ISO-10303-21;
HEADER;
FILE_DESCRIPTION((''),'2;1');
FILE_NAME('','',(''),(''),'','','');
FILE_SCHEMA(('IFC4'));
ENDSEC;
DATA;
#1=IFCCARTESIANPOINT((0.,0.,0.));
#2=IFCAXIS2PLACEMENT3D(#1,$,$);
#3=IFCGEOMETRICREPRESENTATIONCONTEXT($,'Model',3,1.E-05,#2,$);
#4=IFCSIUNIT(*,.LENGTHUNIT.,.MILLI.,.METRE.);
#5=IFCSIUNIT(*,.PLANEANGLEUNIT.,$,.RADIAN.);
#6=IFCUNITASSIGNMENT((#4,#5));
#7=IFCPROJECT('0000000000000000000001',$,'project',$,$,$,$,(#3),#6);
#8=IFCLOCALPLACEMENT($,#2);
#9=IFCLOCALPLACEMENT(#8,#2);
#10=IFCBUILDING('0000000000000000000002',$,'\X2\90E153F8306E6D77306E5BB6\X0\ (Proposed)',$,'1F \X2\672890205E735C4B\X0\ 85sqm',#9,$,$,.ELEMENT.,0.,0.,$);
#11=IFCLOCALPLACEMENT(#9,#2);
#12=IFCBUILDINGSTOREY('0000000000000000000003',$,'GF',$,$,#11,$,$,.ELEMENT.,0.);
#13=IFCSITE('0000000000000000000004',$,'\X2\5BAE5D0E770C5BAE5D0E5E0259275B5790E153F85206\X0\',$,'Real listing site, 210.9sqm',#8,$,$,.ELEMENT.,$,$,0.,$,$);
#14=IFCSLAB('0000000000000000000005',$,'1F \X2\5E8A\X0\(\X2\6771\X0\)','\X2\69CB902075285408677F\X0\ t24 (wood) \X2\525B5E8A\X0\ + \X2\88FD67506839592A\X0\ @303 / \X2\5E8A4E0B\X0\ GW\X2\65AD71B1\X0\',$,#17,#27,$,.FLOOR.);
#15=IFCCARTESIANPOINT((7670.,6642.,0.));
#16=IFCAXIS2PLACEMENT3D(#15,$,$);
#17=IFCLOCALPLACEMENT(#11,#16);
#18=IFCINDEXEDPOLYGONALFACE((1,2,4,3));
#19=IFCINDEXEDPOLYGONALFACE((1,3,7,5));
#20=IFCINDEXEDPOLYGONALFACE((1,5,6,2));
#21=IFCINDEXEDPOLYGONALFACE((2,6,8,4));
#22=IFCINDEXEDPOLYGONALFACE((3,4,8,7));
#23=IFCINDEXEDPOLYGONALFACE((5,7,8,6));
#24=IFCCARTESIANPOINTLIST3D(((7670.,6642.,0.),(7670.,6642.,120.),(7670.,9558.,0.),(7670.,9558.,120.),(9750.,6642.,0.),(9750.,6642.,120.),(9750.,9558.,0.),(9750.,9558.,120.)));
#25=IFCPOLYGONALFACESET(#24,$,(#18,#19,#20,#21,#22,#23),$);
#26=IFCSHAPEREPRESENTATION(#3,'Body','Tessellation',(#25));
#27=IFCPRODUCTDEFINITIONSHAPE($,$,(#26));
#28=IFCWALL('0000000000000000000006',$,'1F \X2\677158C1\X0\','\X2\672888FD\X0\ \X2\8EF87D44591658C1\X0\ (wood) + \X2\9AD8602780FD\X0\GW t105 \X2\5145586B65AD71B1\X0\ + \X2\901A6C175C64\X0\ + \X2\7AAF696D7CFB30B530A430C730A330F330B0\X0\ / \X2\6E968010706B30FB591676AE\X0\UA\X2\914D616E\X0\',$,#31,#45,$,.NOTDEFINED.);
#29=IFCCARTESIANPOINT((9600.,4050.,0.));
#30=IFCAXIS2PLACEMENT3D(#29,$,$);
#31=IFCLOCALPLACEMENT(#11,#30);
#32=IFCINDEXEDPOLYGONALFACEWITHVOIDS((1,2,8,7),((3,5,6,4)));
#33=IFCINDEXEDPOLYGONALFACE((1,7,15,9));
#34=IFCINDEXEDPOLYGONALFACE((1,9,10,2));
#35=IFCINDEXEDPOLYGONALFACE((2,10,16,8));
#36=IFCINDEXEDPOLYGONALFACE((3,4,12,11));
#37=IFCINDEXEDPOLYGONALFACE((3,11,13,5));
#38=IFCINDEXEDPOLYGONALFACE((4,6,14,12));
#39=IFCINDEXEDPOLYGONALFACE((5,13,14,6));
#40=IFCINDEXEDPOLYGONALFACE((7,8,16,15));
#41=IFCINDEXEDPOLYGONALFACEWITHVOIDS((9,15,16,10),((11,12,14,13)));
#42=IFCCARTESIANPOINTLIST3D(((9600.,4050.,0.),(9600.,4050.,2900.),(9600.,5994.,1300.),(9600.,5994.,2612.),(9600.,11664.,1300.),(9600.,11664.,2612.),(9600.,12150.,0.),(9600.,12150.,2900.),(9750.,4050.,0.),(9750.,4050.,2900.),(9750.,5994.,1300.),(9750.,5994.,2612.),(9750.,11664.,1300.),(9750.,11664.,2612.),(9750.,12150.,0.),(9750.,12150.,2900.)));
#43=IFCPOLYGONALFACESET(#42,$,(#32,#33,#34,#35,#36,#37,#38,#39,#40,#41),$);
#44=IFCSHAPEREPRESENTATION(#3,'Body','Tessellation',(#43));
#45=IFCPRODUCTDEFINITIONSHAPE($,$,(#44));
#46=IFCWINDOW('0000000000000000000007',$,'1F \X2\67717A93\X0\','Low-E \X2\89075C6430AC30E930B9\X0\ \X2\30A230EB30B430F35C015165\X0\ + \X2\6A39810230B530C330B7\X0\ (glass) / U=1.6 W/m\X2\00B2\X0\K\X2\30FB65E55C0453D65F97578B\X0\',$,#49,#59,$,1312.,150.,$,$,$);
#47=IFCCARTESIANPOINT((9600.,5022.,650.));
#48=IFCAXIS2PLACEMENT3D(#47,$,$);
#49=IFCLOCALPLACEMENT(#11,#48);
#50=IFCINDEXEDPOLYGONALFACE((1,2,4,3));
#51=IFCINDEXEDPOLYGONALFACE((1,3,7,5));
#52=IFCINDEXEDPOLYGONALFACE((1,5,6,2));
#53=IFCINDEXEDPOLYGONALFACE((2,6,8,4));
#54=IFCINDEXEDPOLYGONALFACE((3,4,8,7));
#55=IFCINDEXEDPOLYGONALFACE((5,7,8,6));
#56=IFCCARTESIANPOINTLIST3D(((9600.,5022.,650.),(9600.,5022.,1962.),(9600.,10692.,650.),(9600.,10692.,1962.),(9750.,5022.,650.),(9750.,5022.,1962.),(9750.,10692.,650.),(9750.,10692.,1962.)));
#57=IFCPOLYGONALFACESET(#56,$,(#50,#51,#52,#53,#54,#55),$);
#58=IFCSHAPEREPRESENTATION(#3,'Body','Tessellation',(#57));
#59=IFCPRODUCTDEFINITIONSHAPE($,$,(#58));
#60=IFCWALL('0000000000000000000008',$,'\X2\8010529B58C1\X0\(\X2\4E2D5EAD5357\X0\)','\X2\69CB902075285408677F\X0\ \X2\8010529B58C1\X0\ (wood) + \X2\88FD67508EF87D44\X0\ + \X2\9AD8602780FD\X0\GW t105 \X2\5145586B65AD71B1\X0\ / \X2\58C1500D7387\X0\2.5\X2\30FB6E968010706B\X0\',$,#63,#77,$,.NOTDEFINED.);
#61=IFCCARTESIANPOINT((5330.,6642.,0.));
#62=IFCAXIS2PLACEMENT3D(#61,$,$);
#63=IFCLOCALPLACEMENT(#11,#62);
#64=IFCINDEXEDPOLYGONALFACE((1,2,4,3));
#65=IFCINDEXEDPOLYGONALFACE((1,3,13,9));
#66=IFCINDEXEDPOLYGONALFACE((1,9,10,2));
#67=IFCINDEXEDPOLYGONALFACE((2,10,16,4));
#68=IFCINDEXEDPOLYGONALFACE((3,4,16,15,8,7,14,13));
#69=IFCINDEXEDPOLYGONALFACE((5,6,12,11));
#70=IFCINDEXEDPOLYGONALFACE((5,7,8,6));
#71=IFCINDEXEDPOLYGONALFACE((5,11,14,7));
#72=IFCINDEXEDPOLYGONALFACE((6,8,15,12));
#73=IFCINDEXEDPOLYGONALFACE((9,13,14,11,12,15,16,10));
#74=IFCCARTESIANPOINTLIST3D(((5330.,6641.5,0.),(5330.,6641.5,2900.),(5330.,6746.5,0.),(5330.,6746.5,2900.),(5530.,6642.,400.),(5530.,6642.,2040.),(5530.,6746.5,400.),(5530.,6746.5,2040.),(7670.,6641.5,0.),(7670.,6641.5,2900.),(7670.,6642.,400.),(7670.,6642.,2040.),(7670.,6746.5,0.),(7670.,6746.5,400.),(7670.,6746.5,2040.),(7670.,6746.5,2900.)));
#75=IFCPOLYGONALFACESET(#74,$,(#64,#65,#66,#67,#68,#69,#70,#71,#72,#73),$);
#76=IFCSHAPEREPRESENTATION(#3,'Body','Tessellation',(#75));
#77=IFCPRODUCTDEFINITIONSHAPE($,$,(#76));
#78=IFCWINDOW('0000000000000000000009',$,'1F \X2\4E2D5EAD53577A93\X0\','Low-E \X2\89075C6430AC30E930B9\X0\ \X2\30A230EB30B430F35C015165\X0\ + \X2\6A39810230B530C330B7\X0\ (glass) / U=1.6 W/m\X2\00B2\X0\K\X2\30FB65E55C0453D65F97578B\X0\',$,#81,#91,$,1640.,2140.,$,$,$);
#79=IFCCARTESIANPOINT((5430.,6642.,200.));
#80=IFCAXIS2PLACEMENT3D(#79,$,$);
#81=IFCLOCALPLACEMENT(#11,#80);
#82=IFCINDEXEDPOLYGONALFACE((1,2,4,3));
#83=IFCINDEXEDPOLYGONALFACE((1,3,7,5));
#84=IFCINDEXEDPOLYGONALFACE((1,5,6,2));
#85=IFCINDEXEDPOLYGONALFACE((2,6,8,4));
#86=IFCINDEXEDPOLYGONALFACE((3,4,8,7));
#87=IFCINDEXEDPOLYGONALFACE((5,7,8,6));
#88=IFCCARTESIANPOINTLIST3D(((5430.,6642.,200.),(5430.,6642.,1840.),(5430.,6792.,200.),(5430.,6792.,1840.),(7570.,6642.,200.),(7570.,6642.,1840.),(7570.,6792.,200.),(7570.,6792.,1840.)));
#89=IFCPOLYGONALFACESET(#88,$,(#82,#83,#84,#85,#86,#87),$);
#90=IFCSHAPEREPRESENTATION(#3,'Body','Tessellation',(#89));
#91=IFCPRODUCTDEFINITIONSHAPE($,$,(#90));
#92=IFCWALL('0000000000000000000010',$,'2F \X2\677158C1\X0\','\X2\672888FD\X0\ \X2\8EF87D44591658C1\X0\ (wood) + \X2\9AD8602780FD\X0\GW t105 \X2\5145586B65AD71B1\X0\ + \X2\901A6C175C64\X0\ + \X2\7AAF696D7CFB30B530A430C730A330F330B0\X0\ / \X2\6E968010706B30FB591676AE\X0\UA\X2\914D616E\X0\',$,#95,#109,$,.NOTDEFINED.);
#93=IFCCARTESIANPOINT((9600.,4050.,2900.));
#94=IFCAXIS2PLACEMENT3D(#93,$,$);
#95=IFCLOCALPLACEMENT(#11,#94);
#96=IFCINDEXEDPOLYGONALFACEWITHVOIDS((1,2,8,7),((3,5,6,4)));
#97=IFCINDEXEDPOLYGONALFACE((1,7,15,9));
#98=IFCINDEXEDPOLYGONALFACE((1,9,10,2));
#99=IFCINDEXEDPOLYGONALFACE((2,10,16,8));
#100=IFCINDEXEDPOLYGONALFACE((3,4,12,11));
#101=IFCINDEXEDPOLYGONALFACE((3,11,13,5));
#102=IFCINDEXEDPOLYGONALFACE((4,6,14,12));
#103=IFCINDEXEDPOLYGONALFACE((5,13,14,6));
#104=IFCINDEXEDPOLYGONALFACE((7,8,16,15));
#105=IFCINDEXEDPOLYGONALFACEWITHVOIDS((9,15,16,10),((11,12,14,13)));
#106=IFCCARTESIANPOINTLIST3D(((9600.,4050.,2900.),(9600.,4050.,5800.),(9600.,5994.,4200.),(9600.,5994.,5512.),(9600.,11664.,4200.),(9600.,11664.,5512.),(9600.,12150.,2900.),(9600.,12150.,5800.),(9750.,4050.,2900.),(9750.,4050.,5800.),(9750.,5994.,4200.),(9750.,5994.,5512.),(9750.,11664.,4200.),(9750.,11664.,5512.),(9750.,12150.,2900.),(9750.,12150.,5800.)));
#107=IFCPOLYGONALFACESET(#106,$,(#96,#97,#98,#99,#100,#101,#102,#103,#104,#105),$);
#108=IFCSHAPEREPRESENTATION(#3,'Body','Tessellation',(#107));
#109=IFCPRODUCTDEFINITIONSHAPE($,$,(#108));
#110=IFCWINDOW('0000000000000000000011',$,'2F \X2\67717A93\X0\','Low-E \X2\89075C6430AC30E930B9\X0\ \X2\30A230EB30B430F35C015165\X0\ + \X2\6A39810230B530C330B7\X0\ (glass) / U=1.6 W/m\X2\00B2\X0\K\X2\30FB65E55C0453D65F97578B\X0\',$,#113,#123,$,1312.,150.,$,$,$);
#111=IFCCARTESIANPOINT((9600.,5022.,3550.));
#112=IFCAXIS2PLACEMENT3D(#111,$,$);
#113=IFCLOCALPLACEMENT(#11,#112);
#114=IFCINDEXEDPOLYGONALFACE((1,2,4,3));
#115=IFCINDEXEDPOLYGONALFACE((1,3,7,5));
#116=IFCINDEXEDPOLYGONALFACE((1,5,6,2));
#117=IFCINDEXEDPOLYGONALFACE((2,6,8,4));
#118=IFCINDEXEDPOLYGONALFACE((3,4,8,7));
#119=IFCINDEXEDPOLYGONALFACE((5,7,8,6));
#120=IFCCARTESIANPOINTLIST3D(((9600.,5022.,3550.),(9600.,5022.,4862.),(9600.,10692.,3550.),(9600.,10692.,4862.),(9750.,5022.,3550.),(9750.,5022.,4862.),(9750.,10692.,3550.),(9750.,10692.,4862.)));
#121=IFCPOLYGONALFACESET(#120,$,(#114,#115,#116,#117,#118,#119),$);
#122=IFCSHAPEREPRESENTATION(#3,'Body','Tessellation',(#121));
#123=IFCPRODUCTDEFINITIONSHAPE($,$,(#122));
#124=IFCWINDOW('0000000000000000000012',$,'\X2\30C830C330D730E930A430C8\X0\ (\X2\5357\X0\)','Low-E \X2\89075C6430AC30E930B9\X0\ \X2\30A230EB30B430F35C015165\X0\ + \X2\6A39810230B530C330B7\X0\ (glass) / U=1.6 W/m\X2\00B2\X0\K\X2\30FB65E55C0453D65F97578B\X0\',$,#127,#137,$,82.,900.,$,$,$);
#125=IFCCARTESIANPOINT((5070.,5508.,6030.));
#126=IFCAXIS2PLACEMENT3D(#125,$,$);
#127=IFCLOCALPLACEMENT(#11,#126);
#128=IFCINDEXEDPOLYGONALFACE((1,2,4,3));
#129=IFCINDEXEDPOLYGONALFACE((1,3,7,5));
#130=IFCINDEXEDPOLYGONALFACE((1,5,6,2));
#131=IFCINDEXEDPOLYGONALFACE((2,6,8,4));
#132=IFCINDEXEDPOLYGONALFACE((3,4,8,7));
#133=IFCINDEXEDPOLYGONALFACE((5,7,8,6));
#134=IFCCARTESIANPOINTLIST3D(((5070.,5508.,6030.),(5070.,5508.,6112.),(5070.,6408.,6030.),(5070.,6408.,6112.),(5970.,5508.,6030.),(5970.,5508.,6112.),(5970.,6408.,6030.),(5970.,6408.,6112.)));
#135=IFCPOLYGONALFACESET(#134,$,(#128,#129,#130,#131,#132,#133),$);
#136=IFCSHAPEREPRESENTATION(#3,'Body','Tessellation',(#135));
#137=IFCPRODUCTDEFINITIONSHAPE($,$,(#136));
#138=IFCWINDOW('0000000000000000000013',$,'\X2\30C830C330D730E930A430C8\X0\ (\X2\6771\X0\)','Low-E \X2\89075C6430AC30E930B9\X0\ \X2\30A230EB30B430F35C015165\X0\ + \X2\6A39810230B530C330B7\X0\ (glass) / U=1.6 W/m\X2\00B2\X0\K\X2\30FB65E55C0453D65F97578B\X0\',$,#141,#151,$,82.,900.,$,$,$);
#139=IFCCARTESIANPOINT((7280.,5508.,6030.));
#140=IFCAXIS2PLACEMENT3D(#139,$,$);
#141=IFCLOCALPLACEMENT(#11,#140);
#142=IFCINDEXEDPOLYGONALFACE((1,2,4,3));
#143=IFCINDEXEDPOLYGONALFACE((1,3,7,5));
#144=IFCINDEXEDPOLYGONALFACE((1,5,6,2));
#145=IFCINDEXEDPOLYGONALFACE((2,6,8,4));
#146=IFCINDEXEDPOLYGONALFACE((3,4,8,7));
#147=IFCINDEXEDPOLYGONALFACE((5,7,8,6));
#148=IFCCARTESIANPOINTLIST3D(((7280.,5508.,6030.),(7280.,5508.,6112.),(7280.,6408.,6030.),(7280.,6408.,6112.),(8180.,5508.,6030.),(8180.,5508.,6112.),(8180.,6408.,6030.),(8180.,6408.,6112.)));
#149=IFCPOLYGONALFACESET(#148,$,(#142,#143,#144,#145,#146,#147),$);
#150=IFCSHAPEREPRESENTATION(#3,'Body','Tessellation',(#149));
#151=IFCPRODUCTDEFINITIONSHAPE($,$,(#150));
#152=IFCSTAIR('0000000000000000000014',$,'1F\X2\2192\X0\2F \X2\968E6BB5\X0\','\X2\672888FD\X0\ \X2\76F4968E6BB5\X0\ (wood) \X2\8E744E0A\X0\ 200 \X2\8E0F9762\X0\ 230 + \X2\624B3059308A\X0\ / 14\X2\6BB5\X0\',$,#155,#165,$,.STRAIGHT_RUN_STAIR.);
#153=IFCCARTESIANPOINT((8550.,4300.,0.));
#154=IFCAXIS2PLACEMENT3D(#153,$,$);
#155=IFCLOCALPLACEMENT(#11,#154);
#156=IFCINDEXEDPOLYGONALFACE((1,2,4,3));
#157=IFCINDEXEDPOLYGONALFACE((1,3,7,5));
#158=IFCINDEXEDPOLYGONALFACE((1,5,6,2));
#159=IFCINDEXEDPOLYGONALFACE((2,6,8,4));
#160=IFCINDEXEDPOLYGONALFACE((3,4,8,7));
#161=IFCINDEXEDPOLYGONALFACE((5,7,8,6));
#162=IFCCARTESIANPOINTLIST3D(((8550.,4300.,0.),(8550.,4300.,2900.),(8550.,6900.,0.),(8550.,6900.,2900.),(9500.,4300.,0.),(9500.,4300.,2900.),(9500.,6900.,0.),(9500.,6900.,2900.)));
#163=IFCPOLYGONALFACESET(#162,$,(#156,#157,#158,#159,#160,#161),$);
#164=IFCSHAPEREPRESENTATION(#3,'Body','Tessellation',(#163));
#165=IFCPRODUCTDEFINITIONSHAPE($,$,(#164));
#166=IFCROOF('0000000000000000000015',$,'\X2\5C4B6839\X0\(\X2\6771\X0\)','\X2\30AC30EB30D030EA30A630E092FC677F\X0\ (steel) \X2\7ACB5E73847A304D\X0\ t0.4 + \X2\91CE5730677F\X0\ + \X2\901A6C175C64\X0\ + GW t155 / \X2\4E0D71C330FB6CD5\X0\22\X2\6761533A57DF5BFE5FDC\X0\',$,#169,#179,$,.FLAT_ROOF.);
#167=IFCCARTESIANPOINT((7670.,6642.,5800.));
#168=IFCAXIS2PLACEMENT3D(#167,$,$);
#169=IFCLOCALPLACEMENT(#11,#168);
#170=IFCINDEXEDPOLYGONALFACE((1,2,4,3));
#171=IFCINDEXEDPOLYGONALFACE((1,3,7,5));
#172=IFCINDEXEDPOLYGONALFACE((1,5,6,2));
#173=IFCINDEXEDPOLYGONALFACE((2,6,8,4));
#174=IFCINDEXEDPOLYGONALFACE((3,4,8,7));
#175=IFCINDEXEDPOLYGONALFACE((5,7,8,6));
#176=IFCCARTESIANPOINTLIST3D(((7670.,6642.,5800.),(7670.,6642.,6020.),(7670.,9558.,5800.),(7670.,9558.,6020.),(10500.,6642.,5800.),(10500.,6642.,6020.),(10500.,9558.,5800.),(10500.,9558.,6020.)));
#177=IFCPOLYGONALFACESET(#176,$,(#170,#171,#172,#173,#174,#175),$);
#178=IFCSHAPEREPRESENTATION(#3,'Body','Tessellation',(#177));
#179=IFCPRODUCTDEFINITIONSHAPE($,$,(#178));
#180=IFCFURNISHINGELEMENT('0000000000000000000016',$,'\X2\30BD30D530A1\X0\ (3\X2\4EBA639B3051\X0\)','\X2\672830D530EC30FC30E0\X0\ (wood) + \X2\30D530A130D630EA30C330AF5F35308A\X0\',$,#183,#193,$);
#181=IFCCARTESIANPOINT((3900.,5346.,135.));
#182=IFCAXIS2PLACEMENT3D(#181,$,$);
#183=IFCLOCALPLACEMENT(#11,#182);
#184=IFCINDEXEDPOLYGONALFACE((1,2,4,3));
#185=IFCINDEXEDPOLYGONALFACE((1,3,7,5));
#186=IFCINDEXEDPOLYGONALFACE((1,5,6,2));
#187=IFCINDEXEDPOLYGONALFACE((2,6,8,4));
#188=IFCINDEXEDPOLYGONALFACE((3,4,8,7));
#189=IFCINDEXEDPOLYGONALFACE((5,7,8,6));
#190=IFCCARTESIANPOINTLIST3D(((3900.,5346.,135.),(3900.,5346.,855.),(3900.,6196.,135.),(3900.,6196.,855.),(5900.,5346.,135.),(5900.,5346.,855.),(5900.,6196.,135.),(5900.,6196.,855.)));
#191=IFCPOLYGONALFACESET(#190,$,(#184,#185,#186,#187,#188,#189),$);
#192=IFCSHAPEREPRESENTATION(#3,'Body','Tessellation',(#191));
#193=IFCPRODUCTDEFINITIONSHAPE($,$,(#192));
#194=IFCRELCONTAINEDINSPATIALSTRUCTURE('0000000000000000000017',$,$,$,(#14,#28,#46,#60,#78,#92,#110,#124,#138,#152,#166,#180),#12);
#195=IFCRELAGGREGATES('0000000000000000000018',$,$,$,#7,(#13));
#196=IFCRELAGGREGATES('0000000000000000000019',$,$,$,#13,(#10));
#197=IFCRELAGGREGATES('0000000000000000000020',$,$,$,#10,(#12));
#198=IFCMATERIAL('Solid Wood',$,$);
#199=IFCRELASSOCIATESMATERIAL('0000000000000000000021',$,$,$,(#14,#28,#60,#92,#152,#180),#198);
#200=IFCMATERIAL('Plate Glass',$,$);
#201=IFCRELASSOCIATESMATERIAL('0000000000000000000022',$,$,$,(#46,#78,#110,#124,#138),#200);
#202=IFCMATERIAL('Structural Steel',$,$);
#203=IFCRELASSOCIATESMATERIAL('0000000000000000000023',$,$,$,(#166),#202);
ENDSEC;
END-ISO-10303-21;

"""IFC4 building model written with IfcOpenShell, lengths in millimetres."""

from ifc_helpers import new_model, si_unit, frame, frame_2d, origin, place, context, project, spatial, rectangle, extrude, material, element, fill, save


model = new_model("IFC4")

# Units and contexts
model_context = context("Model", 3, precision=1e-05, world=origin())
ifc_project = project(units=[si_unit("LENGTHUNIT", "METRE", prefix="MILLI"), si_unit("PLANEANGLEUNIT", "RADIAN")], contexts=[model_context])

# Site, building, storey
site_placement = place(None, origin())
site = spatial("IfcSite", under=ifc_project, at=site_placement, Name="宮崎県宮崎市大字郡司分", ObjectType="Real listing site, 210.9sqm", CompositionType="ELEMENT", RefElevation=0.0)
building_placement = place(site_placement, origin())
building = spatial("IfcBuilding", under=site, at=building_placement, Name="郡司の海の家 (Proposed)", ObjectType="1F 木造平屋 85sqm", CompositionType="ELEMENT", ElevationOfRefHeight=0.0, ElevationOfTerrain=0.0)
storey_placement = place(building_placement, origin())
storey = spatial("IfcBuildingStorey", under=building, at=storey_placement, Name="GF", CompositionType="ELEMENT", Elevation=0.0)

# Slab
ifc_material_1 = material(Name="Solid Wood")
slab_placement = place(storey_placement, frame((7670.0, 6642.0, 0.0)))
element("IfcSlab", 1, at=slab_placement, inside=storey, material=ifc_material_1, Name="1F 床(東)", Description="構造用合板 t24 (wood) 剛床 + 製材根太 @303 / 床下 GW断熱", PredefinedType="FLOOR", context=model_context, shape_type="SweptSolid", body=[
    extrude(rectangle(XDim=2080.0, YDim=2916.0, at=frame_2d((1040.0, 1458.0))), frame((7670.0, 6642.0, 0.0)), (0.0, 0.0, 1.0), 120.0),
])

# Walls, openings, windows
wall_1_placement = place(storey_placement, frame((9600.0, 4050.0, 0.0)))
wall_1 = element("IfcWall", 2, at=wall_1_placement, inside=storey, material=ifc_material_1, Name="1F 東壁", Description="木製 軸組外壁 (wood) + 高性能GW t105 充填断熱 + 通気層 + 窯業系サイディング / 準耐火・外皮UA配慮", PredefinedType="NOTDEFINED", context=model_context, shape_type="SweptSolid", body=[
    extrude(rectangle(XDim=150.0, YDim=8100.0, at=frame_2d((75.0, 4050.0))), frame((9600.0, 4050.0, 0.0)), (0.0, 0.0, 1.0), 2900.0),
])
opening_1_placement = place(storey_placement, frame((9600.0, 5022.0, 650.0)))
opening_1 = element("IfcOpeningElement", 3, at=opening_1_placement, cuts=wall_1, PredefinedType="NOTDEFINED", context=model_context, shape_type="SweptSolid", body=[
    extrude(rectangle(XDim=150.0, YDim=5670.0, at=frame_2d((75.0, 2835.0))), frame((9600.0, 5022.0, 650.0)), (0.0, 0.0, 1.0), 1312.0),
])
ifc_material_2 = material(Name="Plate Glass")
window_1_placement = place(storey_placement, frame((9600.0, 5022.0, 650.0)))
window_1 = element("IfcWindow", 4, at=window_1_placement, inside=storey, material=ifc_material_2, Name="1F 東窓", Description="Low-E 複層ガラス アルゴン封入 + 樹脂サッシ (glass) / U=1.6 W/m²K・日射取得型", OverallHeight=1312.0, OverallWidth=150.0, context=model_context, shape_type="SweptSolid", body=[
    extrude(rectangle(XDim=150.0, YDim=5670.0, at=frame_2d((75.0, 2835.0))), frame((9600.0, 5022.0, 650.0)), (0.0, 0.0, 1.0), 1312.0),
])
fill(opening_1, window_1)
wall_2_placement = place(storey_placement, frame((5330.0, 6642.0, 0.0)))
wall_2 = element("IfcWall", 5, at=wall_2_placement, inside=storey, material=ifc_material_1, Name="耐力壁(中庭南)", Description="構造用合板 耐力壁 (wood) + 製材軸組 + 高性能GW t105 充填断熱 / 壁倍率2.5・準耐火", PredefinedType="NOTDEFINED", context=model_context, shape_type="SweptSolid", body=[
    extrude(rectangle(XDim=2340.0, YDim=105.0, at=frame_2d((1170.0, 52.0))), frame((5330.0, 6642.0, 0.0)), (0.0, 0.0, 1.0), 2900.0),
])
opening_2_placement = place(storey_placement, frame((5430.0, 6642.0, 200.0)))
opening_2 = element("IfcOpeningElement", 6, at=opening_2_placement, cuts=wall_2, PredefinedType="NOTDEFINED", context=model_context, shape_type="SweptSolid", body=[
    extrude(rectangle(XDim=2140.0, YDim=150.0, at=frame_2d((1070.0, 75.0))), frame((5430.0, 6642.0, 200.0)), (0.0, 0.0, 1.0), 1640.0),
])
window_2_placement = place(storey_placement, frame((5430.0, 6642.0, 200.0)))
window_2 = element("IfcWindow", 7, at=window_2_placement, inside=storey, material=ifc_material_2, Name="1F 中庭南窓", Description="Low-E 複層ガラス アルゴン封入 + 樹脂サッシ (glass) / U=1.6 W/m²K・日射取得型", OverallHeight=1640.0, OverallWidth=2140.0, context=model_context, shape_type="SweptSolid", body=[
    extrude(rectangle(XDim=2140.0, YDim=150.0, at=frame_2d((1070.0, 75.0))), frame((5430.0, 6642.0, 200.0)), (0.0, 0.0, 1.0), 1640.0),
])
fill(opening_2, window_2)

# Wall, opening, window
wall_3_placement = place(storey_placement, frame((9600.0, 4050.0, 2900.0)))
wall_3 = element("IfcWall", 8, at=wall_3_placement, inside=storey, material=ifc_material_1, Name="2F 東壁", Description="木製 軸組外壁 (wood) + 高性能GW t105 充填断熱 + 通気層 + 窯業系サイディング / 準耐火・外皮UA配慮", PredefinedType="NOTDEFINED", context=model_context, shape_type="SweptSolid", body=[
    extrude(rectangle(XDim=150.0, YDim=8100.0, at=frame_2d((75.0, 4050.0))), frame((9600.0, 4050.0, 2900.0)), (0.0, 0.0, 1.0), 2900.0),
])
opening_3_placement = place(storey_placement, frame((9600.0, 5022.0, 3550.0)))
opening_3 = element("IfcOpeningElement", 9, at=opening_3_placement, cuts=wall_3, PredefinedType="NOTDEFINED", context=model_context, shape_type="SweptSolid", body=[
    extrude(rectangle(XDim=150.0, YDim=5670.0, at=frame_2d((75.0, 2835.0))), frame((9600.0, 5022.0, 3550.0)), (0.0, 0.0, 1.0), 1312.0),
])
window_3_placement = place(storey_placement, frame((9600.0, 5022.0, 3550.0)))
window_3 = element("IfcWindow", 10, at=window_3_placement, inside=storey, material=ifc_material_2, Name="2F 東窓", Description="Low-E 複層ガラス アルゴン封入 + 樹脂サッシ (glass) / U=1.6 W/m²K・日射取得型", OverallHeight=1312.0, OverallWidth=150.0, context=model_context, shape_type="SweptSolid", body=[
    extrude(rectangle(XDim=150.0, YDim=5670.0, at=frame_2d((75.0, 2835.0))), frame((9600.0, 5022.0, 3550.0)), (0.0, 0.0, 1.0), 1312.0),
])
fill(opening_3, window_3)

# Windows
window_4_placement = place(storey_placement, frame((5070.0, 5508.0, 6030.0)))
element("IfcWindow", 11, at=window_4_placement, inside=storey, material=ifc_material_2, Name="トップライト (南)", Description="Low-E 複層ガラス アルゴン封入 + 樹脂サッシ (glass) / U=1.6 W/m²K・日射取得型", OverallHeight=82.0, OverallWidth=900.0, context=model_context, shape_type="SweptSolid", body=[
    extrude(rectangle(XDim=900.0, YDim=900.0, at=frame_2d((450.0, 450.0))), frame((5070.0, 5508.0, 6030.0)), (0.0, 0.0, 1.0), 82.0),
])
window_5_placement = place(storey_placement, frame((7280.0, 5508.0, 6030.0)))
element("IfcWindow", 12, at=window_5_placement, inside=storey, material=ifc_material_2, Name="トップライト (東)", Description="Low-E 複層ガラス アルゴン封入 + 樹脂サッシ (glass) / U=1.6 W/m²K・日射取得型", OverallHeight=82.0, OverallWidth=900.0, context=model_context, shape_type="SweptSolid", body=[
    extrude(rectangle(XDim=900.0, YDim=900.0, at=frame_2d((450.0, 450.0))), frame((7280.0, 5508.0, 6030.0)), (0.0, 0.0, 1.0), 82.0),
])

# Stair
stair_placement = place(storey_placement, frame((8550.0, 4300.0, 0.0)))
element("IfcStair", 13, at=stair_placement, inside=storey, material=ifc_material_1, Name="1F→2F 階段", Description="木製 直階段 (wood) 蹴上 200 踏面 230 + 手すり / 14段", PredefinedType="STRAIGHT_RUN_STAIR", context=model_context, shape_type="SweptSolid", body=[
    extrude(rectangle(XDim=950.0, YDim=2600.0, at=frame_2d((475.0, 1300.0))), frame((8550.0, 4300.0, 0.0)), (0.0, 0.0, 1.0), 2900.0),
])

# Roof
ifc_material_3 = material(Name="Structural Steel")
roof_placement = place(storey_placement, frame((7670.0, 6642.0, 5800.0)))
element("IfcRoof", 14, at=roof_placement, inside=storey, material=ifc_material_3, Name="屋根(東)", Description="ガルバリウム鋼板 (steel) 立平葺き t0.4 + 野地板 + 通気層 + GW t155 / 不燃・法22条区域対応", PredefinedType="FLAT_ROOF", context=model_context, shape_type="SweptSolid", body=[
    extrude(rectangle(XDim=2830.0, YDim=2916.0, at=frame_2d((1415.0, 1458.0))), frame((7670.0, 6642.0, 5800.0)), (0.0, 0.0, 1.0), 220.0),
])

# Furnishing element
furnishing_1_placement = place(storey_placement, frame((3900.0, 5346.0, 135.0)))
element("IfcFurnishingElement", 15, at=furnishing_1_placement, inside=storey, material=ifc_material_1, Name="ソファ (3人掛け)", Description="木フレーム (wood) + ファブリック張り", context=model_context, shape_type="SweptSolid", body=[
    extrude(rectangle(XDim=2000.0, YDim=850.0, at=frame_2d((1000.0, 425.0))), frame((3900.0, 5346.0, 135.0)), (0.0, 0.0, 1.0), 720.0),
])

save(model, "model.ifc")
